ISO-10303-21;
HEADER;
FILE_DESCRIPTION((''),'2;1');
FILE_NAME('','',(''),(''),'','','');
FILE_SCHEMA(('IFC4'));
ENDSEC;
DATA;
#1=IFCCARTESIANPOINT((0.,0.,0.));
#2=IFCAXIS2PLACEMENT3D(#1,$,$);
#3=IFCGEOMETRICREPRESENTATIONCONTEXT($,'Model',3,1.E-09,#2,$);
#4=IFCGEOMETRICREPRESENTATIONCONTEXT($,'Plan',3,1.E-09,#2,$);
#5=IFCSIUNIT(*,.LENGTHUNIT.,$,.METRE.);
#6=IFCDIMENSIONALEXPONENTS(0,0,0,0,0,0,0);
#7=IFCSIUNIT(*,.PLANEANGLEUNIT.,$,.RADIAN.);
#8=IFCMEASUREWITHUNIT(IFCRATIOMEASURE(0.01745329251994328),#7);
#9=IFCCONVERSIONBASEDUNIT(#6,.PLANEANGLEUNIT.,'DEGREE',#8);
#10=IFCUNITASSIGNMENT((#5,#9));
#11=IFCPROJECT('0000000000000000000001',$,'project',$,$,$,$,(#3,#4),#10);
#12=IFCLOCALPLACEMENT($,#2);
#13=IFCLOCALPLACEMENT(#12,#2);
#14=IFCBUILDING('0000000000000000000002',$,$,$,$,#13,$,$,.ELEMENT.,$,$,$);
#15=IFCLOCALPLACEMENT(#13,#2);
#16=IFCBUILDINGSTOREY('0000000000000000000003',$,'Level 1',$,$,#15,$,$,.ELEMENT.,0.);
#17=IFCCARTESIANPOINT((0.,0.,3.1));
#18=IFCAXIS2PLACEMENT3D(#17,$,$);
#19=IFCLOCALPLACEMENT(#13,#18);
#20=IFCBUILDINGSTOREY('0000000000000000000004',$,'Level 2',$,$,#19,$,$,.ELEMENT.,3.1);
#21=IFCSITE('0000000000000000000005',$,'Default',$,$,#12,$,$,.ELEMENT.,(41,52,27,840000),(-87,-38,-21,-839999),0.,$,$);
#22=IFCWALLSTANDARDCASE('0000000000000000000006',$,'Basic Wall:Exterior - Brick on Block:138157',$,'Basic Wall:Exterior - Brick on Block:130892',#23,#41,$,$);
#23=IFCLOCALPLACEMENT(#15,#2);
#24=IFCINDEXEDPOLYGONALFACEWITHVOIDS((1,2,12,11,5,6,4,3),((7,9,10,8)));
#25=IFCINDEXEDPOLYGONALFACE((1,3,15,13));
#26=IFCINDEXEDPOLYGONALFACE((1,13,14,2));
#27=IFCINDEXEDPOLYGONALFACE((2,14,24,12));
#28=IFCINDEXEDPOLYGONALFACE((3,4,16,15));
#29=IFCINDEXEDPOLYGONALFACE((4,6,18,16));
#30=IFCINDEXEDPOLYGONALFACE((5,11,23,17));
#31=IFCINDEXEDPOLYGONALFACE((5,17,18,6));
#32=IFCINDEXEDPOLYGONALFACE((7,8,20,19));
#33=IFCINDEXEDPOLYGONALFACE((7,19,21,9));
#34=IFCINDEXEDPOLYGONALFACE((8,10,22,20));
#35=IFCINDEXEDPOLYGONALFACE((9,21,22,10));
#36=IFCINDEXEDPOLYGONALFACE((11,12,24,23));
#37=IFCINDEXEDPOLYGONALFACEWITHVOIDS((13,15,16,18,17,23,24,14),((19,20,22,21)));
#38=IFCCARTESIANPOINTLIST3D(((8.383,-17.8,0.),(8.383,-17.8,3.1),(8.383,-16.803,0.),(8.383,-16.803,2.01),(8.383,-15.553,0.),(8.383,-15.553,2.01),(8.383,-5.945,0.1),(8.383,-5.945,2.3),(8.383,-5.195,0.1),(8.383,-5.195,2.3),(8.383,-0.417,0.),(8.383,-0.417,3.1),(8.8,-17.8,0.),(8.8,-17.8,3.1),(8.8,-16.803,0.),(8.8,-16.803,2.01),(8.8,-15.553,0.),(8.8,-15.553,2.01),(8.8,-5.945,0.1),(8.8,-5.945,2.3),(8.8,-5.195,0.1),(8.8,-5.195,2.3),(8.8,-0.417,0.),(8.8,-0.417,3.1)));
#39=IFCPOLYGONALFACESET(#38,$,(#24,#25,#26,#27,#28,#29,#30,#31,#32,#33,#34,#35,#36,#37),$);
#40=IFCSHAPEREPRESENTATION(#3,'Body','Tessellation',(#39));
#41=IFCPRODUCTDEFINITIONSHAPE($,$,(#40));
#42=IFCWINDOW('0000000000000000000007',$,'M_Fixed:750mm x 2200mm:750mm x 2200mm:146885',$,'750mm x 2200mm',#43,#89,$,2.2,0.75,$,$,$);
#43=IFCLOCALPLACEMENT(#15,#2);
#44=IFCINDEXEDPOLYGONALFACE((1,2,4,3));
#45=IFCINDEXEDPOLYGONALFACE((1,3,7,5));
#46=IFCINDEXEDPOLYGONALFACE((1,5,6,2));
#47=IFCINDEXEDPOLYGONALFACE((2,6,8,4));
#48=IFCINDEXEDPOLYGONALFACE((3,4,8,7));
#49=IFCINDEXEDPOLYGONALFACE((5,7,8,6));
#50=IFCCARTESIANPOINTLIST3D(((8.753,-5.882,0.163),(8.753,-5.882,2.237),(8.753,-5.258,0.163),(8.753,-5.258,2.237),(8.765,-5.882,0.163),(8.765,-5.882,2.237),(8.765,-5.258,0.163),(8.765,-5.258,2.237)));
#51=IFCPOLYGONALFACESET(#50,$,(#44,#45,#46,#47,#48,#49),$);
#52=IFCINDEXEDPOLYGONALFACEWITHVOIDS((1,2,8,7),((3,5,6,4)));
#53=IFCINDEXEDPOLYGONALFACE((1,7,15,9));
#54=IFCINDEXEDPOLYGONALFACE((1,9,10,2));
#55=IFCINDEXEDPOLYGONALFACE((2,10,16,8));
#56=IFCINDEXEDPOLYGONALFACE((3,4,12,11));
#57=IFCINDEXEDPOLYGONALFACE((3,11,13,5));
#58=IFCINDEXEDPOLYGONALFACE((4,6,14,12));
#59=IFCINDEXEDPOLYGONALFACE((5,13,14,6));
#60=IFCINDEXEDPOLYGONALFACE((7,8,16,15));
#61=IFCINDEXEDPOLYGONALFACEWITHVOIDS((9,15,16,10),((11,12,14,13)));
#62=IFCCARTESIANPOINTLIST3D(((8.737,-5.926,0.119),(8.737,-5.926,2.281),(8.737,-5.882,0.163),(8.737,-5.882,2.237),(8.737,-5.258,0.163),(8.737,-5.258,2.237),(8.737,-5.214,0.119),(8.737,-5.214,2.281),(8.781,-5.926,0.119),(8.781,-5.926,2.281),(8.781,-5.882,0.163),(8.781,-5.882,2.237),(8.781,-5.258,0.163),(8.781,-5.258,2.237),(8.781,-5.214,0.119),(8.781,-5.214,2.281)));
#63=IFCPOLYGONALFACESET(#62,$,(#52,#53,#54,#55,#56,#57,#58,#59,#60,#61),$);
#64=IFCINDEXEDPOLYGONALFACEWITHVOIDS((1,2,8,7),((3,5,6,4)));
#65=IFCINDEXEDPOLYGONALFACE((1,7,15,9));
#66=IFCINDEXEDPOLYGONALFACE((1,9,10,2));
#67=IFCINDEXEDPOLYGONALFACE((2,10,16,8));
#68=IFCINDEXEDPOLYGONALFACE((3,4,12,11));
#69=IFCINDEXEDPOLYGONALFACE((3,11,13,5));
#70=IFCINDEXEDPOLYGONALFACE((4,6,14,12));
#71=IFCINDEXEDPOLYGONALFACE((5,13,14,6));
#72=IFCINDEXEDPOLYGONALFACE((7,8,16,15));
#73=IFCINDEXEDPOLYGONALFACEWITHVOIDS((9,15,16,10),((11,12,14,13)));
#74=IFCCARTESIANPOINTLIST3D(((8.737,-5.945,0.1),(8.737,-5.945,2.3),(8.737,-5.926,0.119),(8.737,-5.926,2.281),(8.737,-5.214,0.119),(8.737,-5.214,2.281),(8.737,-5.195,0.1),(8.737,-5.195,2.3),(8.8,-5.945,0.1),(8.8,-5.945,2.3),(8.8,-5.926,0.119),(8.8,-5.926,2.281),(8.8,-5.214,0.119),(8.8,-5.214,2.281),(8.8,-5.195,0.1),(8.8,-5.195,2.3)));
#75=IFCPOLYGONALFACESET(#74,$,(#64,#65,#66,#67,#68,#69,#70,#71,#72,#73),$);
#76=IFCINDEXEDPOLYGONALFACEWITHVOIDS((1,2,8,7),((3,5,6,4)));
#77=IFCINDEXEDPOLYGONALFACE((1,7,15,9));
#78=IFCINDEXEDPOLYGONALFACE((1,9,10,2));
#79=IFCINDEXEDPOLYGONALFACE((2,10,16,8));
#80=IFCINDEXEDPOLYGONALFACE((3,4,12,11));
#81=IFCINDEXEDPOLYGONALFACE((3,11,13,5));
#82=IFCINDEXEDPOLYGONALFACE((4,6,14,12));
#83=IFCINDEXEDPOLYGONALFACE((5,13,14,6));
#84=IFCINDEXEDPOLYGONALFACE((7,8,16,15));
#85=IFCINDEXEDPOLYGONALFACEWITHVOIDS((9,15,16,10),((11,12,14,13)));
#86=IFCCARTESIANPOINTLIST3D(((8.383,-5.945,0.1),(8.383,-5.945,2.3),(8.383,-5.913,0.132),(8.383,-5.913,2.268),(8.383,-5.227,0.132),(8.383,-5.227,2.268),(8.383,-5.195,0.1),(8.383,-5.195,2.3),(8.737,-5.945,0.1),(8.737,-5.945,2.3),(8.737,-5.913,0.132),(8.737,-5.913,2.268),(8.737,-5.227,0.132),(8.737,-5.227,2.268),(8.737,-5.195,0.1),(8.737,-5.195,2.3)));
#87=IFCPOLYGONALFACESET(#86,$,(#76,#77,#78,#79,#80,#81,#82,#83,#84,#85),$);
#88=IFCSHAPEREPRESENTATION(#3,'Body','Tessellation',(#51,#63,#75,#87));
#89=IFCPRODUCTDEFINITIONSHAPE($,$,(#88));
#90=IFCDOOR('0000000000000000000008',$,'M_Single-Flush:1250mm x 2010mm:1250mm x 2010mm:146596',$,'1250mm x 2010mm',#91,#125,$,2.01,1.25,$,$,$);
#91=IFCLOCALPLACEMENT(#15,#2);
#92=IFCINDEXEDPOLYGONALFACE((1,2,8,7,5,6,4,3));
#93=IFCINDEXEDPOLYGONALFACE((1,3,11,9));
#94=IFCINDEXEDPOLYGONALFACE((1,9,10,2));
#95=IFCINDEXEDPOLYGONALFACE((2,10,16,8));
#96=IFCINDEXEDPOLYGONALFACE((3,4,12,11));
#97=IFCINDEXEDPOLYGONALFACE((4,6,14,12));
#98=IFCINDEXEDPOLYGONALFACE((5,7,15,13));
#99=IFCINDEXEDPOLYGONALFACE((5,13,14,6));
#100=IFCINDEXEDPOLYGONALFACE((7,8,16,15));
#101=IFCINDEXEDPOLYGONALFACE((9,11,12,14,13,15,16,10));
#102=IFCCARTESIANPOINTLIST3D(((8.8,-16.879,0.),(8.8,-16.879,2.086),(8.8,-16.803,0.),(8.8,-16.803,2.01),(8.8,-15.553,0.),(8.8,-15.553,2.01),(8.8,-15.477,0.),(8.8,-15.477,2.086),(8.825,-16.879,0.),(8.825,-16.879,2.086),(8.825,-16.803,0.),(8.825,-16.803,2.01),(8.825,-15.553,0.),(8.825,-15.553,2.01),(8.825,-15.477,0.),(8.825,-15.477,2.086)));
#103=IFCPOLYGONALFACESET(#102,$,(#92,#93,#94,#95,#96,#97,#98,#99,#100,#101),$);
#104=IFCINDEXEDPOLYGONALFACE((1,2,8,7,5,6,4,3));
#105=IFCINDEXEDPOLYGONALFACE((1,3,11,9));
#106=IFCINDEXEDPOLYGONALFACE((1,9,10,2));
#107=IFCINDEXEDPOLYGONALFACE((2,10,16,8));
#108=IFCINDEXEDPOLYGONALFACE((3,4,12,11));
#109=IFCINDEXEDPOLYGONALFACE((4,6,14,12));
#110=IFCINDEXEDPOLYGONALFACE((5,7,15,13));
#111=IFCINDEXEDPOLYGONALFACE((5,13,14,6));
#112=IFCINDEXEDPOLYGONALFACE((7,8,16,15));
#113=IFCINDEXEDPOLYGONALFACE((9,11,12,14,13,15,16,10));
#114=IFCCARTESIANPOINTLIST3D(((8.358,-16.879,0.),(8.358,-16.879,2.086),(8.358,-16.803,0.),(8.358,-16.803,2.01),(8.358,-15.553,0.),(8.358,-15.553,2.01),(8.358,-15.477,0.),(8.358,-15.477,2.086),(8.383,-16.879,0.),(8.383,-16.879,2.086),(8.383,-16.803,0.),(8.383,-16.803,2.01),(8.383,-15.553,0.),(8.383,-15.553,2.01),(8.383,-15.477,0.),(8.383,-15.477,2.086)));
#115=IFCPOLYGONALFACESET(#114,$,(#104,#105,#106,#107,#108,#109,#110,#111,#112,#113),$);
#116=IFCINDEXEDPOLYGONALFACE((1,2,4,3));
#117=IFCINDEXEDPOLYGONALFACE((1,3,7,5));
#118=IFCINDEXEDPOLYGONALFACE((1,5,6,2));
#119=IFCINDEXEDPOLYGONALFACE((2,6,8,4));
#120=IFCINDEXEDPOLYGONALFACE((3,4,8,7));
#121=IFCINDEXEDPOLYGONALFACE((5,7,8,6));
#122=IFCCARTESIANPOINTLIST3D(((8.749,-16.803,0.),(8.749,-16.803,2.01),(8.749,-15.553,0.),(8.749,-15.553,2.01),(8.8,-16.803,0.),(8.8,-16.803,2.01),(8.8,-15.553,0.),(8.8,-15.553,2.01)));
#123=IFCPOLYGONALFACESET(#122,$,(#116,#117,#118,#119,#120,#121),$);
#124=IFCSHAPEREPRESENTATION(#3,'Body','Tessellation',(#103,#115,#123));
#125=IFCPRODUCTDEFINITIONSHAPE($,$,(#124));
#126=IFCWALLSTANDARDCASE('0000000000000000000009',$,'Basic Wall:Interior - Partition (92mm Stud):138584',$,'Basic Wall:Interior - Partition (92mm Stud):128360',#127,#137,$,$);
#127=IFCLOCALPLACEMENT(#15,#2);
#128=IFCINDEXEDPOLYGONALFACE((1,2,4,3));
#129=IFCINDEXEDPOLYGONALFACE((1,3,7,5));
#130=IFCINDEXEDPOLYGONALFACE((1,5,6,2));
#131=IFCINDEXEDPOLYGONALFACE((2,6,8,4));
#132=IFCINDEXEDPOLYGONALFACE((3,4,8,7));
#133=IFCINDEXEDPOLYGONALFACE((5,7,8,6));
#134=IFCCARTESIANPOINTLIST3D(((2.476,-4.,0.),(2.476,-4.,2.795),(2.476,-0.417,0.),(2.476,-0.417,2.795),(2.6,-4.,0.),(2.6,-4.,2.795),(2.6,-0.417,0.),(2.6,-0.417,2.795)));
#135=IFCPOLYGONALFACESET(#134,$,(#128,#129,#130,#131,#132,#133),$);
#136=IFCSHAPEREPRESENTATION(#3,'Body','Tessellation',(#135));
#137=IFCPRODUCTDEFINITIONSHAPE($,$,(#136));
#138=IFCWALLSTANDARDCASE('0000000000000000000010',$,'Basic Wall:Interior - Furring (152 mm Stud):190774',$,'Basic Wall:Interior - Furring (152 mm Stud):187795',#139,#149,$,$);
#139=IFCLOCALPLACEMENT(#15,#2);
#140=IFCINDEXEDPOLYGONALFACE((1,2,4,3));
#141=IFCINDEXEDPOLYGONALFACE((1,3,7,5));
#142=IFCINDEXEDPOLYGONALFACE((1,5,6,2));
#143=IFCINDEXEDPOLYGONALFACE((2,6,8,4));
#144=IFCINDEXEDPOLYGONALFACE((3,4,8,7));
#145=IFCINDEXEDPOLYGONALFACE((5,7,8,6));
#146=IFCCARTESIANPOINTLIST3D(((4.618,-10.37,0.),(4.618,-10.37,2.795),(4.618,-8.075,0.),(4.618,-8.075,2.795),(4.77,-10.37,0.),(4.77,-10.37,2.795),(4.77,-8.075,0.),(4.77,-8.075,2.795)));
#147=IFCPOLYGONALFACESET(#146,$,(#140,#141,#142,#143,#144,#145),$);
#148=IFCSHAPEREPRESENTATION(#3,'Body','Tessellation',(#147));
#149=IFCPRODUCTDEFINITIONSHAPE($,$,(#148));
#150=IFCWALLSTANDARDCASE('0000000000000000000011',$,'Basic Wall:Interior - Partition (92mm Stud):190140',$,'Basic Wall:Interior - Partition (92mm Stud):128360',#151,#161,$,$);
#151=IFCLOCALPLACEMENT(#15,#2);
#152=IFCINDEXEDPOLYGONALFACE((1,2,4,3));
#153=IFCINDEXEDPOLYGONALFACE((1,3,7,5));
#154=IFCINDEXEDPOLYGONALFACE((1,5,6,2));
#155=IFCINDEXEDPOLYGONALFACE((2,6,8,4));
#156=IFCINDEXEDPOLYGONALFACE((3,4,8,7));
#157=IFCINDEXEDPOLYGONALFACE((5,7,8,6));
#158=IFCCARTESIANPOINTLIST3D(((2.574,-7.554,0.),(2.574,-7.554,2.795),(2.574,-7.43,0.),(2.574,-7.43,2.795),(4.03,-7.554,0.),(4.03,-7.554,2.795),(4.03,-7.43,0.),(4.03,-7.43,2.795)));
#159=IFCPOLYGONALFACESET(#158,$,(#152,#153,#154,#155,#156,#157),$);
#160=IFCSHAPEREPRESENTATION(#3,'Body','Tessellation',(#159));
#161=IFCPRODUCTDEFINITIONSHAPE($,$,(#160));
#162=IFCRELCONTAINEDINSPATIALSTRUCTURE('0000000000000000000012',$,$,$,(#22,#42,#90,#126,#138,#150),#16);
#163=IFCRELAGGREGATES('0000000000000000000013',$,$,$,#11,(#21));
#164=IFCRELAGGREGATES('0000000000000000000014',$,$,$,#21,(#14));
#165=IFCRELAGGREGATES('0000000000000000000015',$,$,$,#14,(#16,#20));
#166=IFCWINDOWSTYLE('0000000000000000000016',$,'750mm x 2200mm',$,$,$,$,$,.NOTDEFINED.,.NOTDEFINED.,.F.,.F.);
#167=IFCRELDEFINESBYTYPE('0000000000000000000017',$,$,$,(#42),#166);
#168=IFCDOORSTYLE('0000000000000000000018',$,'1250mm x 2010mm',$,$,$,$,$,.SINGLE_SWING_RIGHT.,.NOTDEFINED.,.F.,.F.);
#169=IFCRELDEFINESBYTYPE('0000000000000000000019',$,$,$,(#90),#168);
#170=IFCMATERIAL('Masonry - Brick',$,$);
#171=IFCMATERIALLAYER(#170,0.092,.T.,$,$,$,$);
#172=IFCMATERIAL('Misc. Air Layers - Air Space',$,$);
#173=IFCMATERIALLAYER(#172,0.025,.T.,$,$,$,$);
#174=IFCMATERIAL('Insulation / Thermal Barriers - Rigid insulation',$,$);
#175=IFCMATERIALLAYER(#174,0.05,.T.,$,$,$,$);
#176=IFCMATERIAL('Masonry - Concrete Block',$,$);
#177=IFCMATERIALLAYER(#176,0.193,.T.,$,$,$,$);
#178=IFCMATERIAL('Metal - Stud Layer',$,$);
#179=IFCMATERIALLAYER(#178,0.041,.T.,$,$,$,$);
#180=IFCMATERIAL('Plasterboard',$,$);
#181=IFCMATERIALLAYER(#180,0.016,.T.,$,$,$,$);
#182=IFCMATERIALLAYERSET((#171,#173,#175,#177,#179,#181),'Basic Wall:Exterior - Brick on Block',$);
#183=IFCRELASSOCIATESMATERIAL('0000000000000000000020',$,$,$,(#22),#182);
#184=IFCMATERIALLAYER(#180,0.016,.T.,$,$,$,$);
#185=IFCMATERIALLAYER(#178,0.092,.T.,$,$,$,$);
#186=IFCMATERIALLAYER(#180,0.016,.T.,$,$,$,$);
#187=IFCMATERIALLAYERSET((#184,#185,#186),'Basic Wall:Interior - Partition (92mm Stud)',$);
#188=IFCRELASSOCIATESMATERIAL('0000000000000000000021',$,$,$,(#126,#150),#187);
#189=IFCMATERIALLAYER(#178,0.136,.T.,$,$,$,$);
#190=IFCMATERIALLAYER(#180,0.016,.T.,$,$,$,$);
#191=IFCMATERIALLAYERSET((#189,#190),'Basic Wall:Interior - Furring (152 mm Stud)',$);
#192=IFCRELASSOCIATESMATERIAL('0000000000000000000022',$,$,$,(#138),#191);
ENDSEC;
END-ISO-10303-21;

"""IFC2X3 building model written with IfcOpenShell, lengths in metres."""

from ifc_helpers import new_model, entity, si_unit, converted_unit, frame, frame_2d, origin, origin_2d_with_axis, place, context, project, spatial, polyline, rectangle, outline, extrude, source, transform, mapped, material, layer, layer_set, layer_usage, type_object, type_shapes, element, fill, save


model = new_model("IFC2X3")

# Units and contexts
model_context = context("Model", 3, precision=1e-09, world=origin())
plan_context = context("Plan", 3, precision=1e-09, world=origin())
ifc_project = project(units=[si_unit("LENGTHUNIT", "METRE"), converted_unit("PLANEANGLEUNIT", "DEGREE", entity("IfcRatioMeasure", 0.01745329251994328), si_unit("PLANEANGLEUNIT", "RADIAN"), dimensions=[0, 0, 0, 0, 0, 0, 0])], contexts=[model_context, plan_context])

# Site, building, storey
site_placement = place(None, origin())
site = spatial("IfcSite", under=ifc_project, at=site_placement, Name="Default", CompositionType="ELEMENT", RefLatitude=(41, 52, 27, 840000), RefLongitude=(-87, -38, -21, -839999), RefElevation=0.0)
building_placement = place(site_placement, origin())
building = spatial("IfcBuilding", under=site, at=building_placement, CompositionType="ELEMENT")
storey_1_placement = place(building_placement, origin())
storey_1 = spatial("IfcBuildingStorey", under=building, at=storey_1_placement, Name="Level 1", CompositionType="ELEMENT", Elevation=0.0)

# Shared definitions
ifc_material_1 = material(Name="Masonry - Brick")
ifc_layer_1 = layer(ifc_material_1, 0.092, ventilated=True)
ifc_material_2 = material(Name="Misc. Air Layers - Air Space")
ifc_layer_2 = layer(ifc_material_2, 0.025, ventilated=True)
ifc_material_3 = material(Name="Insulation / Thermal Barriers - Rigid insulation")
ifc_layer_3 = layer(ifc_material_3, 0.05, ventilated=True)
ifc_material_4 = material(Name="Masonry - Concrete Block")
ifc_layer_4 = layer(ifc_material_4, 0.193, ventilated=True)
ifc_material_5 = material(Name="Metal - Stud Layer")
ifc_layer_5 = layer(ifc_material_5, 0.041, ventilated=True)
ifc_material_6 = material(Name="Plasterboard")
ifc_layer_6 = layer(ifc_material_6, 0.016, ventilated=True)
ifc_layer_set_1 = layer_set([ifc_layer_1, ifc_layer_2, ifc_layer_3, ifc_layer_4, ifc_layer_5, ifc_layer_6], Name="Basic Wall:Exterior - Brick on Block")
ifc_layer_usage_1 = layer_usage(ifc_layer_set_1, "AXIS2", "NEGATIVE", 0.2085)

# Shared definitions
ifc_layer_7 = layer(ifc_material_6, 0.016, ventilated=True)
ifc_layer_8 = layer(ifc_material_5, 0.092, ventilated=True)
ifc_layer_9 = layer(ifc_material_6, 0.016, ventilated=True)
ifc_layer_set_2 = layer_set([ifc_layer_7, ifc_layer_8, ifc_layer_9], Name="Basic Wall:Interior - Partition (92mm Stud)")
ifc_layer_usage_2 = layer_usage(ifc_layer_set_2, "AXIS2", "NEGATIVE", 0.062)

# Wall, openings, window, door
wall_1_placement = place(storey_1_placement, frame((8.5915, -0.417, 0.0), z_axis=(0.0, 0.0, 1.0), x_axis=(0.0, -1.0, 0.0)))
wall_1 = element("IfcWallStandardCase", 1, at=wall_1_placement, inside=storey_1, material=ifc_layer_usage_1, Name="Basic Wall:Exterior - Brick on Block:138157", ObjectType="Basic Wall:Exterior - Brick on Block:130892", context=model_context, shape_type="SweptSolid", body=[
    extrude(rectangle(XDim=17.383, YDim=0.417, at=frame_2d((8.6915, 0.0), x_axis=(-1.0, 0.0))), origin(), (0.0, 0.0, 1.0), 3.1),
])
opening_1_placement = place(wall_1_placement, frame((15.136, -0.2085, 0.0)))
opening_1 = element("IfcOpeningElement", 2, at=opening_1_placement, cuts=wall_1, ObjectType="Opening", context=model_context, shape_type="SweptSolid", body=[
    extrude(rectangle(XDim=1.25, YDim=2.01, at=frame_2d((1.005, 0.625), x_axis=(0.0, 1.0))), frame((0.0, 0.0, 0.0), z_axis=(0.0, 1.0, 0.0), x_axis=(0.0, 0.0, 1.0)), (0.0, 0.0, 1.0), 0.417),
])
opening_2_placement = place(wall_1_placement, frame((4.778, -0.2085, 0.1)))
opening_2 = element("IfcOpeningElement", 3, at=opening_2_placement, cuts=wall_1, ObjectType="Opening", context=model_context, shape_type="SweptSolid", body=[
    extrude(rectangle(XDim=2.2, YDim=0.75, at=frame_2d((1.1, 0.375), x_axis=(1.0, 0.0))), frame((0.0, 0.0, 0.0), z_axis=(0.0, 1.0, 0.0), x_axis=(0.0, 0.0, 1.0)), (0.0, 0.0, 1.0), 0.417),
])
window_style_1 = type_object("IfcWindowStyle", Name="750mm x 2200mm", ConstructionType="NOTDEFINED", OperationType="NOTDEFINED", ParameterTakesPrecedence=False, Sizeable=False)
shared_shape_1 = source(origin(), model_context, "Body", "SweptSolid", [
    extrude(rectangle(XDim=0.012, YDim=0.624, at=origin_2d_with_axis()), frame((0.375, 0.376, 0.063), z_axis=(0.0, 0.0, 1.0), x_axis=(0.0, -1.0, 0.0)), (0.0, 0.0, 1.0), 2.074),
    extrude(outline(polyline([(-0.356, -1.081), (0.356, -1.081), (0.356, 1.081), (-0.356, 1.081), (-0.356, -1.081)]), holes=[polyline([(-0.312, -1.037), (-0.312, 1.037), (0.312, 1.037), (0.312, -1.037), (-0.312, -1.037)])]), frame((0.375, 0.354, 1.1), z_axis=(0.0, 1.0, 0.0), x_axis=(1.0, 0.0, 0.0)), (0.0, 0.0, 1.0), 0.044),
    extrude(outline(polyline([(-0.375, -1.1), (0.375, -1.1), (0.375, 1.1), (-0.375, 1.1), (-0.375, -1.1)]), holes=[polyline([(-0.356, -1.081), (-0.356, 1.081), (0.356, 1.081), (0.356, -1.081), (-0.356, -1.081)])]), frame((0.375, 0.354, 1.1), z_axis=(0.0, 1.0, 0.0), x_axis=(1.0, 0.0, 0.0)), (0.0, 0.0, 1.0), 0.063),
    extrude(outline(polyline([(-0.375, -1.1), (0.375, -1.1), (0.375, 1.1), (-0.375, 1.1), (-0.375, -1.1)]), holes=[polyline([(-0.343, -1.068), (-0.343, 1.068), (0.343, 1.068), (0.343, -1.068), (-0.343, -1.068)])]), frame((0.375, 0.0, 1.1), z_axis=(0.0, 1.0, 0.0), x_axis=(1.0, 0.0, 0.0)), (0.0, 0.0, 1.0), 0.354),
])
type_shapes(window_style_1, [shared_shape_1])
window_1_placement = place(opening_2_placement, origin())
window_1 = element("IfcWindow", 4, at=window_1_placement, inside=storey_1, type_object=window_style_1, Name="M_Fixed:750mm x 2200mm:750mm x 2200mm:146885", ObjectType="750mm x 2200mm", OverallHeight=2.2, OverallWidth=0.75, context=model_context, shape_type="MappedRepresentation", body=[
    mapped(shared_shape_1, transform((0.0, 0.0, 0.0), scale=1.0)),
])
fill(opening_2, window_1)
door_style_1 = type_object("IfcDoorStyle", Name="1250mm x 2010mm", ConstructionType="NOTDEFINED", OperationType="SINGLE_SWING_RIGHT", ParameterTakesPrecedence=False, Sizeable=False)
shared_shape_2 = source(origin(), model_context, "Body", "SweptSolid", [
    extrude(outline(polyline([(-0.701, -1.062), (0.701, -1.062), (0.701, 1.024), (0.625, 1.024), (0.625, -0.986), (-0.625, -0.986), (-0.625, 1.024), (-0.701, 1.024), (-0.701, -1.062)])), frame((0.625, 0.417, 1.024), z_axis=(0.0, 1.0, 0.0), x_axis=(1.0, 0.0, 0.0)), (0.0, 0.0, 1.0), 0.025),
    extrude(outline(polyline([(-1.062, -0.701), (1.024, -0.701), (1.024, -0.625), (-0.986, -0.625), (-0.986, 0.625), (1.024, 0.625), (1.024, 0.701), (-1.062, 0.701), (-1.062, -0.701)])), frame((0.625, -0.025, 1.024), z_axis=(0.0, 1.0, 0.0), x_axis=(0.0, 0.0, -1.0)), (0.0, 0.0, 1.0), 0.025),
    extrude(rectangle(XDim=0.051, YDim=1.25, at=origin_2d_with_axis()), frame((0.625, 0.3915, 0.0), z_axis=(0.0, 0.0, 1.0), x_axis=(0.0, 1.0, 0.0)), (0.0, 0.0, 1.0), 2.01),
])
type_shapes(door_style_1, [shared_shape_2])
door_1_placement = place(opening_1_placement, origin())
door_1 = element("IfcDoor", 5, at=door_1_placement, inside=storey_1, type_object=door_style_1, Name="M_Single-Flush:1250mm x 2010mm:1250mm x 2010mm:146596", ObjectType="1250mm x 2010mm", OverallHeight=2.01, OverallWidth=1.25, context=model_context, shape_type="MappedRepresentation", body=[
    mapped(shared_shape_2, transform((0.0, 0.0, 0.0), scale=1.0)),
])
fill(opening_1, door_1)

# Walls
wall_2_placement = place(storey_1_placement, frame((2.538, -0.417, 0.0), z_axis=(0.0, 0.0, 1.0), x_axis=(0.0, -1.0, 0.0)))
element("IfcWallStandardCase", 6, at=wall_2_placement, inside=storey_1, material=ifc_layer_usage_2, Name="Basic Wall:Interior - Partition (92mm Stud):138584", ObjectType="Basic Wall:Interior - Partition (92mm Stud):128360", context=model_context, shape_type="SweptSolid", body=[
    extrude(rectangle(XDim=3.583, YDim=0.124, at=frame_2d((1.7915, 0.0), x_axis=(-1.0, 0.0))), origin(), (0.0, 0.0, 1.0), 2.795),
])
ifc_layer_10 = layer(ifc_material_5, 0.136, ventilated=True)
ifc_layer_11 = layer(ifc_material_6, 0.016, ventilated=True)
ifc_layer_set_3 = layer_set([ifc_layer_10, ifc_layer_11], Name="Basic Wall:Interior - Furring (152 mm Stud)")
ifc_layer_usage_3 = layer_usage(ifc_layer_set_3, "AXIS2", "POSITIVE", -0.076)
wall_3_placement = place(storey_1_placement, frame((4.694, -8.075, 0.0), z_axis=(0.0, 0.0, 1.0), x_axis=(0.0, -1.0, 0.0)))
element("IfcWallStandardCase", 7, at=wall_3_placement, inside=storey_1, material=ifc_layer_usage_3, Name="Basic Wall:Interior - Furring (152 mm Stud):190774", ObjectType="Basic Wall:Interior - Furring (152 mm Stud):187795", context=model_context, shape_type="SweptSolid", body=[
    extrude(rectangle(XDim=2.295, YDim=0.152, at=frame_2d((1.1475, 0.0), x_axis=(-1.0, 0.0))), origin(), (0.0, 0.0, 1.0), 2.795),
])

# Shared definitions
storey_2_placement = place(building_placement, frame((0.0, 0.0, 3.1)))
storey_2 = spatial("IfcBuildingStorey", under=building, at=storey_2_placement, Name="Level 2", CompositionType="ELEMENT", Elevation=3.1)

# Wall
wall_4_placement = place(storey_1_placement, frame((4.03, -7.492, 0.0), z_axis=(0.0, 0.0, 1.0), x_axis=(-1.0, 0.0, 0.0)))
element("IfcWallStandardCase", 8, at=wall_4_placement, inside=storey_1, material=ifc_layer_usage_2, Name="Basic Wall:Interior - Partition (92mm Stud):190140", ObjectType="Basic Wall:Interior - Partition (92mm Stud):128360", context=model_context, shape_type="SweptSolid", body=[
    extrude(rectangle(XDim=1.456, YDim=0.124, at=frame_2d((0.728, 0.0), x_axis=(-1.0, 0.0))), origin(), (0.0, 0.0, 1.0), 2.795),
])

save(model, "model.ifc")
